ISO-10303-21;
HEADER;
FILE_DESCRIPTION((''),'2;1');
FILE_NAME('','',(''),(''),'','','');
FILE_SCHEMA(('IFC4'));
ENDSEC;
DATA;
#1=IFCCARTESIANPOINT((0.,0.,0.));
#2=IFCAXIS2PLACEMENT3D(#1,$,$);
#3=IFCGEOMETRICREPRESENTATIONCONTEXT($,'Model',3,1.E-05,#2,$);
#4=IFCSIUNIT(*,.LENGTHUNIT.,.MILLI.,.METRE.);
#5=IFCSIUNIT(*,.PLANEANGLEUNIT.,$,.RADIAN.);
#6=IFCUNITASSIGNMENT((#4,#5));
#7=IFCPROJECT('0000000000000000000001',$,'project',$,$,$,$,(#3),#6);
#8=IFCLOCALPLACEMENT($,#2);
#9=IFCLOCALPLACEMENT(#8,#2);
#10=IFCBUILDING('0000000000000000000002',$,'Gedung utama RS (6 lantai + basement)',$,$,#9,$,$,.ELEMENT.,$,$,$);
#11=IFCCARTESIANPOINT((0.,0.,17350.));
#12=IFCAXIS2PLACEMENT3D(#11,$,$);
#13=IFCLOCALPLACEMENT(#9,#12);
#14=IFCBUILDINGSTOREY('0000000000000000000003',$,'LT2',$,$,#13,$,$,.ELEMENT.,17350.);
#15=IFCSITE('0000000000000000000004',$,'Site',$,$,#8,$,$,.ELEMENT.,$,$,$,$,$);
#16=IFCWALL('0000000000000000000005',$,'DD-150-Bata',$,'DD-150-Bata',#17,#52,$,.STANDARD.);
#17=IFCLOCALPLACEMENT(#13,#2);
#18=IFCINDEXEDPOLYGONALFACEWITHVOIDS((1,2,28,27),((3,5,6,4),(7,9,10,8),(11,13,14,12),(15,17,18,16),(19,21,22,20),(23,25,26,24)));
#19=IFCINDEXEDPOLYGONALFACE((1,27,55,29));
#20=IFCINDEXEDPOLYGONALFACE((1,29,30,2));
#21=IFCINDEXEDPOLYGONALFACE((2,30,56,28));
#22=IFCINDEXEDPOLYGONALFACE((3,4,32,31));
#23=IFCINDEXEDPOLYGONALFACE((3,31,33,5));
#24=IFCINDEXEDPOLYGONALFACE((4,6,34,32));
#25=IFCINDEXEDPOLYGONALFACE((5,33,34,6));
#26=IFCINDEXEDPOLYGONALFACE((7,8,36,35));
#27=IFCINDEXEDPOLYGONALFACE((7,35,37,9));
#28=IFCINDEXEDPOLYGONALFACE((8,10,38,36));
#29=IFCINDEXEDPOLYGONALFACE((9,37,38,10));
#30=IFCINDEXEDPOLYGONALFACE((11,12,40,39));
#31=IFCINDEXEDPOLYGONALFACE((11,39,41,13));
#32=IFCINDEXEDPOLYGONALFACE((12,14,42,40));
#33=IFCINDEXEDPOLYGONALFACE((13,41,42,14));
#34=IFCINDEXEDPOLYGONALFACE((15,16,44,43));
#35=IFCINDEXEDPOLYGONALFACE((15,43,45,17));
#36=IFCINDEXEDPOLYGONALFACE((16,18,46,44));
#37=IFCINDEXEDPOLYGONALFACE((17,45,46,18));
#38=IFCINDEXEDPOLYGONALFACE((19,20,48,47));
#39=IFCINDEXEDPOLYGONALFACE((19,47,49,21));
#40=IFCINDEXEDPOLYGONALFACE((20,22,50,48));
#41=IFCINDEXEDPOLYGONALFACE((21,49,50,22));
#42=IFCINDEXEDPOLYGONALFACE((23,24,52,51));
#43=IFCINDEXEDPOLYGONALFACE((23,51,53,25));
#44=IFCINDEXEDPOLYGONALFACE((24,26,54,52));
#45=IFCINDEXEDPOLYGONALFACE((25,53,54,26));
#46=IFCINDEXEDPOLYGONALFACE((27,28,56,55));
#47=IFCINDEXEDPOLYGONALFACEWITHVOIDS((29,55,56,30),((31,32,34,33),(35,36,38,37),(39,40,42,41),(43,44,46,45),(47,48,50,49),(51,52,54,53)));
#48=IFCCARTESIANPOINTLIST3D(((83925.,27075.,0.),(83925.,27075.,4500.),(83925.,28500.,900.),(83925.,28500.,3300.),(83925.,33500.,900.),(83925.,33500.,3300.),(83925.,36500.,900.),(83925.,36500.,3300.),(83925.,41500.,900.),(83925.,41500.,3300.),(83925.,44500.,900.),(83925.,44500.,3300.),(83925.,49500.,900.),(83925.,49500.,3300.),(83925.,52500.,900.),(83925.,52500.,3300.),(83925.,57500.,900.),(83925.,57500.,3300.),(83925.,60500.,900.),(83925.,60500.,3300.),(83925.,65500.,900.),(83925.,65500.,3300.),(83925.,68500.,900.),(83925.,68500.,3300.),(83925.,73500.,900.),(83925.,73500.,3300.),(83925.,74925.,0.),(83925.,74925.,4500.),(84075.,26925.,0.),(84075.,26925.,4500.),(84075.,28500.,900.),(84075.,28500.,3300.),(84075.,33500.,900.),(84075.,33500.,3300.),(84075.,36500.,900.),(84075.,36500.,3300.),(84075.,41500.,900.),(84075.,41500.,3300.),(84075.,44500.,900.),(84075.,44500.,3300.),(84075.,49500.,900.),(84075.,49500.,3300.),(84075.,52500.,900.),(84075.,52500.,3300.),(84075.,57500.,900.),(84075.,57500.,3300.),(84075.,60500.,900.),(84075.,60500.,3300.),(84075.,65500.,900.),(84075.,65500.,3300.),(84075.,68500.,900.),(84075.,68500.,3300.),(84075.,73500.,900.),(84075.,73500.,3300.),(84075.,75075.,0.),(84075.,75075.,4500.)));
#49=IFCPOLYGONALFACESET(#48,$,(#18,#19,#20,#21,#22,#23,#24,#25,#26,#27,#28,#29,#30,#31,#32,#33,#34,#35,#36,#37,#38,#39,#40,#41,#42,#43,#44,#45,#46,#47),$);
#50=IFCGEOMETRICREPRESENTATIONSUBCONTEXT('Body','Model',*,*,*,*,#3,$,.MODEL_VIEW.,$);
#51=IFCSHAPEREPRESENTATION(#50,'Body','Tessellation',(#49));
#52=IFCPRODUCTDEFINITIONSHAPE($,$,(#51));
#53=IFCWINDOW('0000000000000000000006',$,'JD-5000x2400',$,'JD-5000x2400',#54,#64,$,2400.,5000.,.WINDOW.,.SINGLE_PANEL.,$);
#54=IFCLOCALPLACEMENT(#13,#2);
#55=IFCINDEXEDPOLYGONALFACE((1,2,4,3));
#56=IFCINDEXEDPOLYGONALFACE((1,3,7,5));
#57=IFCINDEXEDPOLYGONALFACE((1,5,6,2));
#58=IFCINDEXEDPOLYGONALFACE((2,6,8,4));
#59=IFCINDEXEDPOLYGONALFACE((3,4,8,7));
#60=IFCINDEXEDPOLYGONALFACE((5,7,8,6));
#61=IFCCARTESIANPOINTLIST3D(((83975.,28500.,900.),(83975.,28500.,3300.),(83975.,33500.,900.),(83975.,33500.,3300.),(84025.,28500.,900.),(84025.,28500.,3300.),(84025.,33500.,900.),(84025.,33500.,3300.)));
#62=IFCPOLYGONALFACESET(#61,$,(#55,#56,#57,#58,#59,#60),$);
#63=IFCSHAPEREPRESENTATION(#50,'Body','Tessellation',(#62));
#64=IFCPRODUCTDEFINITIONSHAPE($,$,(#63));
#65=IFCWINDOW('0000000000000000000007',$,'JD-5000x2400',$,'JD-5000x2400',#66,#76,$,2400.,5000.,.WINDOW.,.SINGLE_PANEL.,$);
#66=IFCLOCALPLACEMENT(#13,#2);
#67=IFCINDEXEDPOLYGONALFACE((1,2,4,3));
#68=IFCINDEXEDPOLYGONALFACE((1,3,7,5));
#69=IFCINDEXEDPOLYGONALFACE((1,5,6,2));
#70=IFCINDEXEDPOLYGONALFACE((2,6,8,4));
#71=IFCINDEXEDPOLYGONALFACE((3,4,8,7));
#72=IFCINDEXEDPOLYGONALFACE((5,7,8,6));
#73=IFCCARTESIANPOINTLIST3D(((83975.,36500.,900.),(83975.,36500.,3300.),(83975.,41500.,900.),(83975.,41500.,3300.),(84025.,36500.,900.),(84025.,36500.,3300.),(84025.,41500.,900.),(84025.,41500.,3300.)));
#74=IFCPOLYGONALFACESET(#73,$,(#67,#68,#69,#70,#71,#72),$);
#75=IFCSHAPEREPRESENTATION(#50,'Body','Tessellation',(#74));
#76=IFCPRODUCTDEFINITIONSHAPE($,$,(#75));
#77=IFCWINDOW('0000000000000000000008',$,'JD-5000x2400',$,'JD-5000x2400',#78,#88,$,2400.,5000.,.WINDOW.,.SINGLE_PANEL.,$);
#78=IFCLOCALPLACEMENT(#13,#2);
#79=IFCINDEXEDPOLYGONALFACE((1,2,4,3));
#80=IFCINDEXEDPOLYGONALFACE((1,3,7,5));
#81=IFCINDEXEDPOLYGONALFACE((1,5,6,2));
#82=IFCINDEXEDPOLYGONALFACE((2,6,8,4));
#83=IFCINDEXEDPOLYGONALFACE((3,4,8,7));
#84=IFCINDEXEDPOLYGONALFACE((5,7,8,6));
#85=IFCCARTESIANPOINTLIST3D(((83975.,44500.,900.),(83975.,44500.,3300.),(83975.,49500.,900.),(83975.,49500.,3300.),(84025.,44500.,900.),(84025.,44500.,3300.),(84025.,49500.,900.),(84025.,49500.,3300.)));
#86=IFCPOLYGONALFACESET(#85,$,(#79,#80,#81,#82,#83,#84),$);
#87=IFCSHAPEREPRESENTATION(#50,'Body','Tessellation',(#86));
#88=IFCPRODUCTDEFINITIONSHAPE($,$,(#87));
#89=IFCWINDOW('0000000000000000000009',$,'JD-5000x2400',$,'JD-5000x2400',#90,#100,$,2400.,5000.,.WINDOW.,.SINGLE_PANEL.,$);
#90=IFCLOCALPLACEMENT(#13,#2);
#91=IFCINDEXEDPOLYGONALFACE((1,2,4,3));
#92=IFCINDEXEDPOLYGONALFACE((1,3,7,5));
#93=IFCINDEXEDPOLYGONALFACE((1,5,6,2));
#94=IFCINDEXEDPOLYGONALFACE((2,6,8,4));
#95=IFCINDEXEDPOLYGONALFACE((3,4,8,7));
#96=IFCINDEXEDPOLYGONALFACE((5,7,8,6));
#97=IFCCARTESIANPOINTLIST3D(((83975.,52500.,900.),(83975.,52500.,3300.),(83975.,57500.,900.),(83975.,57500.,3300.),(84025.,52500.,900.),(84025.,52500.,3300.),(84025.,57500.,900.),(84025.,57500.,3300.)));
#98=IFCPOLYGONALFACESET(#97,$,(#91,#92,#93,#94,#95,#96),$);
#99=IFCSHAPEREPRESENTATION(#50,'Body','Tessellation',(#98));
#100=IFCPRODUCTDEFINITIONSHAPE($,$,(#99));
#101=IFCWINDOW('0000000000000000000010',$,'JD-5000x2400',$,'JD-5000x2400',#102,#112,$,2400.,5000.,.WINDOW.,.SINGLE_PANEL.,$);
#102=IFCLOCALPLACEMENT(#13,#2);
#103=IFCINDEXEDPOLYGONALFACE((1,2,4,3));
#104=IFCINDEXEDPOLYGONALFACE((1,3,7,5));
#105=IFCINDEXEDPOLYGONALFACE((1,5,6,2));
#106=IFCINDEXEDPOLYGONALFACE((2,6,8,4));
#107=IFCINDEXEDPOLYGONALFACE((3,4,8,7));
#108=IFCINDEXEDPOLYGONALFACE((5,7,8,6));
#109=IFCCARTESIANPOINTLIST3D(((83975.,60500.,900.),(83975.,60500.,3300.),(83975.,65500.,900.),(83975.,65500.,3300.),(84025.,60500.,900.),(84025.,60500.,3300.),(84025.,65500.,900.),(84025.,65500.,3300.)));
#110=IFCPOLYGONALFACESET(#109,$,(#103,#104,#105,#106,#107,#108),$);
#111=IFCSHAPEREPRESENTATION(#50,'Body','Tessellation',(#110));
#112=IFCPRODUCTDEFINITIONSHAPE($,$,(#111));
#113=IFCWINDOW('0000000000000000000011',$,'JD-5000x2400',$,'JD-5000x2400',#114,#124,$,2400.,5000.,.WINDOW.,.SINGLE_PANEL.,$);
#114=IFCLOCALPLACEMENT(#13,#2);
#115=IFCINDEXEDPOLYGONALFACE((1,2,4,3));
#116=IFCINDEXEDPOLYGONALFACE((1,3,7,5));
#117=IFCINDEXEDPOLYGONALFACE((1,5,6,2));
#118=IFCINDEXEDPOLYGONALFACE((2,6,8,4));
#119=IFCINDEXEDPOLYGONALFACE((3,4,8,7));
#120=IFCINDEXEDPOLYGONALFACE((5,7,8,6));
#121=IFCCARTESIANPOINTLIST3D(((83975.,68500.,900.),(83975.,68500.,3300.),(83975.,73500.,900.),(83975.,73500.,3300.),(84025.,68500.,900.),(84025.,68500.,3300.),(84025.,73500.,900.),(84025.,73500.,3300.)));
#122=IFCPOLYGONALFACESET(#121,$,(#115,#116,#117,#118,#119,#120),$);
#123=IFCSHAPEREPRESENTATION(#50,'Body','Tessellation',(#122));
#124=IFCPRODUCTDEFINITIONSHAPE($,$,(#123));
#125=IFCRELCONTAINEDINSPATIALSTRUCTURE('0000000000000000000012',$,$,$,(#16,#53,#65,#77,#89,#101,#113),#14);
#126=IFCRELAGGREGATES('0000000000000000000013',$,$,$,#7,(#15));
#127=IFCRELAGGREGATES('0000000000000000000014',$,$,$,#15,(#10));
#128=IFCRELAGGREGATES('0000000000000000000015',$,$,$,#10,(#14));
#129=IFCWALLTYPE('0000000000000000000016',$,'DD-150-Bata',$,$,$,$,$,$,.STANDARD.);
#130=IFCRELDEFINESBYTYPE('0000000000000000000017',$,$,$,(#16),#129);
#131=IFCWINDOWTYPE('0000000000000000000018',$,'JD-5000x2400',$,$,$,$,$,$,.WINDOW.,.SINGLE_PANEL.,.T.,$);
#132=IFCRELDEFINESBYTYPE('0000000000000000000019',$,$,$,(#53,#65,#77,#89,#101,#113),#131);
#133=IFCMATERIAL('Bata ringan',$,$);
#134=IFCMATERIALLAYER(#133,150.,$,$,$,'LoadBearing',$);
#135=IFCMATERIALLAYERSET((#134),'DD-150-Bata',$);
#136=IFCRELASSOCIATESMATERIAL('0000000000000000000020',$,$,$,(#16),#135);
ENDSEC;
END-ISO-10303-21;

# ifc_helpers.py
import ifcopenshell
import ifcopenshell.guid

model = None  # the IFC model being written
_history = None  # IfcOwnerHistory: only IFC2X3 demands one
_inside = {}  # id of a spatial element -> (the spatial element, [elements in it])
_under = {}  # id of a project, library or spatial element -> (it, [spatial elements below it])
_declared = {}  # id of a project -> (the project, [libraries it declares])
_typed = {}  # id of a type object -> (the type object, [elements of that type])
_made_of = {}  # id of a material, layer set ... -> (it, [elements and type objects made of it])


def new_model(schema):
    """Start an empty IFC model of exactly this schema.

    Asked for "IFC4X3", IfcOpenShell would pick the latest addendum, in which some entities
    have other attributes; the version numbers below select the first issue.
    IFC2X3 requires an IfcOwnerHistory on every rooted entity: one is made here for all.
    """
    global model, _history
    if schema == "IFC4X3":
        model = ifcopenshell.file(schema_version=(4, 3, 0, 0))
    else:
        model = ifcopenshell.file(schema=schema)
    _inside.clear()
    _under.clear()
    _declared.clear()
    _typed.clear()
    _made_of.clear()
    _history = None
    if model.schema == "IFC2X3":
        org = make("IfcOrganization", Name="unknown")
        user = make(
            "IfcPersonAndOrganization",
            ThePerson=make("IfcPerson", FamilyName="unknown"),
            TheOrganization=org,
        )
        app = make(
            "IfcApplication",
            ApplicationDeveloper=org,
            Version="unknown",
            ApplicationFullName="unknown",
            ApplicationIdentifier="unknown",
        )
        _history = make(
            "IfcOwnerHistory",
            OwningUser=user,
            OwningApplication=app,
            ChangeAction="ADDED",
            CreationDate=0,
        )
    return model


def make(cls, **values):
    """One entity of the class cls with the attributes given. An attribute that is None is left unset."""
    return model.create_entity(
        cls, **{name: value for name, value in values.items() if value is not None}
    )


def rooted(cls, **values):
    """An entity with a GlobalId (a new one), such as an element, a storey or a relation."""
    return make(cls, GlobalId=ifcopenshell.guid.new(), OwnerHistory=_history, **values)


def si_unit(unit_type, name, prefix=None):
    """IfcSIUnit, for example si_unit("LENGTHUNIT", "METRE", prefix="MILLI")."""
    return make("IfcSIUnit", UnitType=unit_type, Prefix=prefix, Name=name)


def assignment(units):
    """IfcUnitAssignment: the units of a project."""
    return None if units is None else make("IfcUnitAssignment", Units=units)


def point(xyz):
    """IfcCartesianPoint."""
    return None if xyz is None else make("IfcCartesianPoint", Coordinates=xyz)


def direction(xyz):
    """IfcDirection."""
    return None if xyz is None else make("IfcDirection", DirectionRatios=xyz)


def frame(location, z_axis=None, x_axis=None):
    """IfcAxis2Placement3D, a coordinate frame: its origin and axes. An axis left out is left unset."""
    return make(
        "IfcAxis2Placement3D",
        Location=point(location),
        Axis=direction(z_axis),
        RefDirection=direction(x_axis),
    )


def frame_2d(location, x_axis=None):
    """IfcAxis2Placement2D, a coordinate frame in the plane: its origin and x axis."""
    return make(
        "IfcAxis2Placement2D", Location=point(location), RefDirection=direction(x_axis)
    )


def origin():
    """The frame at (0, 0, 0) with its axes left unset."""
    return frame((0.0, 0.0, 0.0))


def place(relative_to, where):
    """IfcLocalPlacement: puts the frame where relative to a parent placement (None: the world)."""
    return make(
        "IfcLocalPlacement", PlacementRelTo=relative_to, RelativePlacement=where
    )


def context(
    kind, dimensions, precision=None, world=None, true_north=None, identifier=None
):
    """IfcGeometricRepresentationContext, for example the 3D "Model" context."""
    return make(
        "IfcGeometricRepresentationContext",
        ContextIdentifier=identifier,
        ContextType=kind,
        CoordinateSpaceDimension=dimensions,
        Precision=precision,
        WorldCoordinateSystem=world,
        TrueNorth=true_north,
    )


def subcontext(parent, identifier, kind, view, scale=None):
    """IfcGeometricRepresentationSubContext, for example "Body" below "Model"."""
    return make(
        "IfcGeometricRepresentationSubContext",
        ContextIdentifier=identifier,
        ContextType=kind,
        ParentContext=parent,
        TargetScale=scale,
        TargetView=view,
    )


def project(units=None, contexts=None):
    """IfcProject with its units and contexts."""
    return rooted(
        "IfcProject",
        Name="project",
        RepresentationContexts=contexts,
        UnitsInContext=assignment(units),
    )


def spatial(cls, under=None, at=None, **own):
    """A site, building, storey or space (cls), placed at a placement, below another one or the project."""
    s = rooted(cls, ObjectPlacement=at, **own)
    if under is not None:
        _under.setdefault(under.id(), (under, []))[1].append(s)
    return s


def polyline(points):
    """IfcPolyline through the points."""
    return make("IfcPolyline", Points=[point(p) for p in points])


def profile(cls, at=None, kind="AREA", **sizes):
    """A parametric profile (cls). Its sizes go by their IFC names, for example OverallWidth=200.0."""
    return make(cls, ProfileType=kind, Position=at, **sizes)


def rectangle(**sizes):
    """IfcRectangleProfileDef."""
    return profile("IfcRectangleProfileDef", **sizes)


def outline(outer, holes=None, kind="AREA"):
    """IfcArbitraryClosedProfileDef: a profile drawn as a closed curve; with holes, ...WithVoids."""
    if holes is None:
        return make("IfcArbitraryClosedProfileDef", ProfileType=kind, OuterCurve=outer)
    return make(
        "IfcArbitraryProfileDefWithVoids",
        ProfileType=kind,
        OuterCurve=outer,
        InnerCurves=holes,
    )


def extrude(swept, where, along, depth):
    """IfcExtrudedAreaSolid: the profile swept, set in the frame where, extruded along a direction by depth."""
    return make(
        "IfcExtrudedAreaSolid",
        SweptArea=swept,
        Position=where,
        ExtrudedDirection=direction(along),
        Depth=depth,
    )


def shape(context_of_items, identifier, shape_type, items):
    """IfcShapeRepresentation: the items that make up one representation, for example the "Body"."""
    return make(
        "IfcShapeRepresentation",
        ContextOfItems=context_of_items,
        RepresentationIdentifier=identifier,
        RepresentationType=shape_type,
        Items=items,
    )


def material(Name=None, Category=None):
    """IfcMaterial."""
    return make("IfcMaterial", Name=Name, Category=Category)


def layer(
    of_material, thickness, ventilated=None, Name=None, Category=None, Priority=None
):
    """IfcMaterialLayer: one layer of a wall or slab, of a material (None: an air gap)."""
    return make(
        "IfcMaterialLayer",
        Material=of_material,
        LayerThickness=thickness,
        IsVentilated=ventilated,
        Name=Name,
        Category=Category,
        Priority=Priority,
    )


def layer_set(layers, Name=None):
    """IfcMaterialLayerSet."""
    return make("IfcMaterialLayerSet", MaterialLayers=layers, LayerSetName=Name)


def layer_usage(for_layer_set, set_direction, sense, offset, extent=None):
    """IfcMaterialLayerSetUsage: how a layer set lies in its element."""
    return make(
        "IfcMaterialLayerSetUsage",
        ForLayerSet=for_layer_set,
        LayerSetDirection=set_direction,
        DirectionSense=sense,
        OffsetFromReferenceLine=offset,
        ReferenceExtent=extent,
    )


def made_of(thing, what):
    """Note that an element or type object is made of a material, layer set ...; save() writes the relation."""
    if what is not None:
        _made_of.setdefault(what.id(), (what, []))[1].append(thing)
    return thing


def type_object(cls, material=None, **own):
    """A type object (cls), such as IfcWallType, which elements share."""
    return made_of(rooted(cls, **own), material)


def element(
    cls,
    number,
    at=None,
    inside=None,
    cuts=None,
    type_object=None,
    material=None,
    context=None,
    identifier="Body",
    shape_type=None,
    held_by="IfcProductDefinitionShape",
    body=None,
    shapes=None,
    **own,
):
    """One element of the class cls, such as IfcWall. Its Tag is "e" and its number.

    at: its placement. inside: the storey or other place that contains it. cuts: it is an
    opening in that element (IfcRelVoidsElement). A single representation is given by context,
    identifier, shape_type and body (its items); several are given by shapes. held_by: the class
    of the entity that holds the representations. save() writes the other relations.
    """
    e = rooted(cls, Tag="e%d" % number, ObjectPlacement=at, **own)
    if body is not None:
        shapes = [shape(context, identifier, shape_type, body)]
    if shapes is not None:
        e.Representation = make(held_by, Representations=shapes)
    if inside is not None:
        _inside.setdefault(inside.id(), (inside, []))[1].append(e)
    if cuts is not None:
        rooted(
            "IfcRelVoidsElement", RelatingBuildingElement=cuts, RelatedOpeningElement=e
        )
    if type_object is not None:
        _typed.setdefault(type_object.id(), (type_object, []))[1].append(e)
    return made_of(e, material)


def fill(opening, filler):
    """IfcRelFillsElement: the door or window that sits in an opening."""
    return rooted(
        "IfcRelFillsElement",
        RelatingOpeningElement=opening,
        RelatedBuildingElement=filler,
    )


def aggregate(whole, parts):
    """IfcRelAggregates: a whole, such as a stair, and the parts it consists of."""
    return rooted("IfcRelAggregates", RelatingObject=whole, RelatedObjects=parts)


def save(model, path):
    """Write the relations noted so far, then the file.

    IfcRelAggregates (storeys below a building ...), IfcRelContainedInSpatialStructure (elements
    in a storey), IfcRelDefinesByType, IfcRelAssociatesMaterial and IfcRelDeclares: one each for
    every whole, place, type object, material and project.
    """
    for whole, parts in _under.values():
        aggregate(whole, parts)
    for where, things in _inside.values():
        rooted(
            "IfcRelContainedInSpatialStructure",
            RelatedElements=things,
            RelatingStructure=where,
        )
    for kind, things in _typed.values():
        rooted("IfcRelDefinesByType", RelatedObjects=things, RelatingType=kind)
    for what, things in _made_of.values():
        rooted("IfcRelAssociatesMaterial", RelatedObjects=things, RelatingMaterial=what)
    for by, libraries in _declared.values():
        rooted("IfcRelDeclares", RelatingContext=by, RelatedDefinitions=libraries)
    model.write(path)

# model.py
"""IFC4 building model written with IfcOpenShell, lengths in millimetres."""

from ifc_helpers import new_model, si_unit, frame, frame_2d, origin, place, context, subcontext, project, spatial, polyline, rectangle, outline, extrude, material, layer, layer_set, layer_usage, type_object, element, fill, save


model = new_model("IFC4")

# Units and contexts
model_context = context("Model", 3, precision=1e-05, world=origin())
body_context = subcontext(model_context, "Body", "Model", "MODEL_VIEW")
ifc_project = project(units=[si_unit("LENGTHUNIT", "METRE", prefix="MILLI"), si_unit("PLANEANGLEUNIT", "RADIAN")], contexts=[model_context])

# Site, building, storey
site_placement = place(None, origin())
site = spatial("IfcSite", under=ifc_project, at=site_placement, Name="Site", CompositionType="ELEMENT")
building_placement = place(site_placement, origin())
building = spatial("IfcBuilding", under=site, at=building_placement, Name="Gedung utama RS (6 lantai + basement)", CompositionType="ELEMENT")
storey_placement = place(building_placement, frame((0.0, 0.0, 17350.0)))
storey = spatial("IfcBuildingStorey", under=building, at=storey_placement, Name="LT2", CompositionType="ELEMENT", Elevation=17350.0)

# Wall, openings, windows
ifc_material_1 = material(Name="Bata ringan")
ifc_layer = layer(ifc_material_1, 150.0, Category="LoadBearing")
ifc_layer_set = layer_set([ifc_layer], Name="DD-150-Bata")
ifc_layer_usage = layer_usage(ifc_layer_set, "AXIS2", "NEGATIVE", 75.0)
wall_type = type_object("IfcWallType", Name="DD-150-Bata", PredefinedType="STANDARD")
wall_placement = place(storey_placement, frame((84000.0, 27000.0, 0.0), z_axis=(0.0, 0.0, 1.0), x_axis=(0.0, 1.0, 0.0)))
wall = element("IfcWall", 1, at=wall_placement, inside=storey, type_object=wall_type, material=ifc_layer_usage, Name="DD-150-Bata", ObjectType="DD-150-Bata", PredefinedType="STANDARD", context=body_context, shape_type="SweptSolid", body=[
    extrude(outline(polyline([(-75.0, -75.0), (0.0, 0.0), (75.0, 75.0), (47925.0, 75.0), (48000.0, 0.0), (48075.0, -75.0), (-75.0, -75.0)])), origin(), (0.0, 0.0, 1.0), 4500.0),
])
opening_1_placement = place(wall_placement, frame((1500.0, 0.0, 900.0), z_axis=(0.0, 0.0, 1.0), x_axis=(1.0, 0.0, 0.0)))
opening_1 = element("IfcOpeningElement", 2, at=opening_1_placement, cuts=wall, PredefinedType="OPENING", context=body_context, shape_type="SweptSolid", body=[
    extrude(rectangle(XDim=5000.0, YDim=170.0, at=frame_2d((2500.0, 0.0))), origin(), (0.0, 0.0, 1.0), 2400.0),
])
opening_2_placement = place(wall_placement, frame((9500.0, 0.0, 900.0), z_axis=(0.0, 0.0, 1.0), x_axis=(1.0, 0.0, 0.0)))
opening_2 = element("IfcOpeningElement", 3, at=opening_2_placement, cuts=wall, PredefinedType="OPENING", context=body_context, shape_type="SweptSolid", body=[
    extrude(rectangle(XDim=5000.0, YDim=170.0, at=frame_2d((2500.0, 0.0))), origin(), (0.0, 0.0, 1.0), 2400.0),
])
opening_3_placement = place(wall_placement, frame((17500.0, 0.0, 900.0), z_axis=(0.0, 0.0, 1.0), x_axis=(1.0, 0.0, 0.0)))
opening_3 = element("IfcOpeningElement", 4, at=opening_3_placement, cuts=wall, PredefinedType="OPENING", context=body_context, shape_type="SweptSolid", body=[
    extrude(rectangle(XDim=5000.0, YDim=170.0, at=frame_2d((2500.0, 0.0))), origin(), (0.0, 0.0, 1.0), 2400.0),
])
opening_4_placement = place(wall_placement, frame((25500.0, 0.0, 900.0), z_axis=(0.0, 0.0, 1.0), x_axis=(1.0, 0.0, 0.0)))
opening_4 = element("IfcOpeningElement", 5, at=opening_4_placement, cuts=wall, PredefinedType="OPENING", context=body_context, shape_type="SweptSolid", body=[
    extrude(rectangle(XDim=5000.0, YDim=170.0, at=frame_2d((2500.0, 0.0))), origin(), (0.0, 0.0, 1.0), 2400.0),
])
opening_5_placement = place(wall_placement, frame((33500.0, 0.0, 900.0), z_axis=(0.0, 0.0, 1.0), x_axis=(1.0, 0.0, 0.0)))
opening_5 = element("IfcOpeningElement", 6, at=opening_5_placement, cuts=wall, PredefinedType="OPENING", context=body_context, shape_type="SweptSolid", body=[
    extrude(rectangle(XDim=5000.0, YDim=170.0, at=frame_2d((2500.0, 0.0))), origin(), (0.0, 0.0, 1.0), 2400.0),
])
opening_6_placement = place(wall_placement, frame((41500.0, 0.0, 900.0), z_axis=(0.0, 0.0, 1.0), x_axis=(1.0, 0.0, 0.0)))
opening_6 = element("IfcOpeningElement", 7, at=opening_6_placement, cuts=wall, PredefinedType="OPENING", context=body_context, shape_type="SweptSolid", body=[
    extrude(rectangle(XDim=5000.0, YDim=170.0, at=frame_2d((2500.0, 0.0))), origin(), (0.0, 0.0, 1.0), 2400.0),
])
window_type = type_object("IfcWindowType", Name="JD-5000x2400", ParameterTakesPrecedence=True, PartitioningType="SINGLE_PANEL", PredefinedType="WINDOW")
window_1_placement = place(opening_1_placement, origin())
window_1 = element("IfcWindow", 8, at=window_1_placement, inside=storey, type_object=window_type, Name="JD-5000x2400", ObjectType="JD-5000x2400", OverallHeight=2400.0, OverallWidth=5000.0, PartitioningType="SINGLE_PANEL", PredefinedType="WINDOW", context=body_context, shape_type="SweptSolid", body=[
    extrude(rectangle(XDim=5000.0, YDim=50.0, at=frame_2d((2500.0, 0.0))), origin(), (0.0, 0.0, 1.0), 2400.0),
])
fill(opening_1, window_1)
window_2_placement = place(opening_2_placement, origin())
window_2 = element("IfcWindow", 9, at=window_2_placement, inside=storey, type_object=window_type, Name="JD-5000x2400", ObjectType="JD-5000x2400", OverallHeight=2400.0, OverallWidth=5000.0, PartitioningType="SINGLE_PANEL", PredefinedType="WINDOW", context=body_context, shape_type="SweptSolid", body=[
    extrude(rectangle(XDim=5000.0, YDim=50.0, at=frame_2d((2500.0, 0.0))), origin(), (0.0, 0.0, 1.0), 2400.0),
])
fill(opening_2, window_2)
window_3_placement = place(opening_3_placement, origin())
window_3 = element("IfcWindow", 10, at=window_3_placement, inside=storey, type_object=window_type, Name="JD-5000x2400", ObjectType="JD-5000x2400", OverallHeight=2400.0, OverallWidth=5000.0, PartitioningType="SINGLE_PANEL", PredefinedType="WINDOW", context=body_context, shape_type="SweptSolid", body=[
    extrude(rectangle(XDim=5000.0, YDim=50.0, at=frame_2d((2500.0, 0.0))), origin(), (0.0, 0.0, 1.0), 2400.0),
])
fill(opening_3, window_3)
window_4_placement = place(opening_4_placement, origin())
window_4 = element("IfcWindow", 11, at=window_4_placement, inside=storey, type_object=window_type, Name="JD-5000x2400", ObjectType="JD-5000x2400", OverallHeight=2400.0, OverallWidth=5000.0, PartitioningType="SINGLE_PANEL", PredefinedType="WINDOW", context=body_context, shape_type="SweptSolid", body=[
    extrude(rectangle(XDim=5000.0, YDim=50.0, at=frame_2d((2500.0, 0.0))), origin(), (0.0, 0.0, 1.0), 2400.0),
])
fill(opening_4, window_4)
window_5_placement = place(opening_5_placement, origin())
window_5 = element("IfcWindow", 12, at=window_5_placement, inside=storey, type_object=window_type, Name="JD-5000x2400", ObjectType="JD-5000x2400", OverallHeight=2400.0, OverallWidth=5000.0, PartitioningType="SINGLE_PANEL", PredefinedType="WINDOW", context=body_context, shape_type="SweptSolid", body=[
    extrude(rectangle(XDim=5000.0, YDim=50.0, at=frame_2d((2500.0, 0.0))), origin(), (0.0, 0.0, 1.0), 2400.0),
])
fill(opening_5, window_5)
window_6_placement = place(opening_6_placement, origin())
window_6 = element("IfcWindow", 13, at=window_6_placement, inside=storey, type_object=window_type, Name="JD-5000x2400", ObjectType="JD-5000x2400", OverallHeight=2400.0, OverallWidth=5000.0, PartitioningType="SINGLE_PANEL", PredefinedType="WINDOW", context=body_context, shape_type="SweptSolid", body=[
    extrude(rectangle(XDim=5000.0, YDim=50.0, at=frame_2d((2500.0, 0.0))), origin(), (0.0, 0.0, 1.0), 2400.0),
])
fill(opening_6, window_6)

save(model, "model.ifc")
